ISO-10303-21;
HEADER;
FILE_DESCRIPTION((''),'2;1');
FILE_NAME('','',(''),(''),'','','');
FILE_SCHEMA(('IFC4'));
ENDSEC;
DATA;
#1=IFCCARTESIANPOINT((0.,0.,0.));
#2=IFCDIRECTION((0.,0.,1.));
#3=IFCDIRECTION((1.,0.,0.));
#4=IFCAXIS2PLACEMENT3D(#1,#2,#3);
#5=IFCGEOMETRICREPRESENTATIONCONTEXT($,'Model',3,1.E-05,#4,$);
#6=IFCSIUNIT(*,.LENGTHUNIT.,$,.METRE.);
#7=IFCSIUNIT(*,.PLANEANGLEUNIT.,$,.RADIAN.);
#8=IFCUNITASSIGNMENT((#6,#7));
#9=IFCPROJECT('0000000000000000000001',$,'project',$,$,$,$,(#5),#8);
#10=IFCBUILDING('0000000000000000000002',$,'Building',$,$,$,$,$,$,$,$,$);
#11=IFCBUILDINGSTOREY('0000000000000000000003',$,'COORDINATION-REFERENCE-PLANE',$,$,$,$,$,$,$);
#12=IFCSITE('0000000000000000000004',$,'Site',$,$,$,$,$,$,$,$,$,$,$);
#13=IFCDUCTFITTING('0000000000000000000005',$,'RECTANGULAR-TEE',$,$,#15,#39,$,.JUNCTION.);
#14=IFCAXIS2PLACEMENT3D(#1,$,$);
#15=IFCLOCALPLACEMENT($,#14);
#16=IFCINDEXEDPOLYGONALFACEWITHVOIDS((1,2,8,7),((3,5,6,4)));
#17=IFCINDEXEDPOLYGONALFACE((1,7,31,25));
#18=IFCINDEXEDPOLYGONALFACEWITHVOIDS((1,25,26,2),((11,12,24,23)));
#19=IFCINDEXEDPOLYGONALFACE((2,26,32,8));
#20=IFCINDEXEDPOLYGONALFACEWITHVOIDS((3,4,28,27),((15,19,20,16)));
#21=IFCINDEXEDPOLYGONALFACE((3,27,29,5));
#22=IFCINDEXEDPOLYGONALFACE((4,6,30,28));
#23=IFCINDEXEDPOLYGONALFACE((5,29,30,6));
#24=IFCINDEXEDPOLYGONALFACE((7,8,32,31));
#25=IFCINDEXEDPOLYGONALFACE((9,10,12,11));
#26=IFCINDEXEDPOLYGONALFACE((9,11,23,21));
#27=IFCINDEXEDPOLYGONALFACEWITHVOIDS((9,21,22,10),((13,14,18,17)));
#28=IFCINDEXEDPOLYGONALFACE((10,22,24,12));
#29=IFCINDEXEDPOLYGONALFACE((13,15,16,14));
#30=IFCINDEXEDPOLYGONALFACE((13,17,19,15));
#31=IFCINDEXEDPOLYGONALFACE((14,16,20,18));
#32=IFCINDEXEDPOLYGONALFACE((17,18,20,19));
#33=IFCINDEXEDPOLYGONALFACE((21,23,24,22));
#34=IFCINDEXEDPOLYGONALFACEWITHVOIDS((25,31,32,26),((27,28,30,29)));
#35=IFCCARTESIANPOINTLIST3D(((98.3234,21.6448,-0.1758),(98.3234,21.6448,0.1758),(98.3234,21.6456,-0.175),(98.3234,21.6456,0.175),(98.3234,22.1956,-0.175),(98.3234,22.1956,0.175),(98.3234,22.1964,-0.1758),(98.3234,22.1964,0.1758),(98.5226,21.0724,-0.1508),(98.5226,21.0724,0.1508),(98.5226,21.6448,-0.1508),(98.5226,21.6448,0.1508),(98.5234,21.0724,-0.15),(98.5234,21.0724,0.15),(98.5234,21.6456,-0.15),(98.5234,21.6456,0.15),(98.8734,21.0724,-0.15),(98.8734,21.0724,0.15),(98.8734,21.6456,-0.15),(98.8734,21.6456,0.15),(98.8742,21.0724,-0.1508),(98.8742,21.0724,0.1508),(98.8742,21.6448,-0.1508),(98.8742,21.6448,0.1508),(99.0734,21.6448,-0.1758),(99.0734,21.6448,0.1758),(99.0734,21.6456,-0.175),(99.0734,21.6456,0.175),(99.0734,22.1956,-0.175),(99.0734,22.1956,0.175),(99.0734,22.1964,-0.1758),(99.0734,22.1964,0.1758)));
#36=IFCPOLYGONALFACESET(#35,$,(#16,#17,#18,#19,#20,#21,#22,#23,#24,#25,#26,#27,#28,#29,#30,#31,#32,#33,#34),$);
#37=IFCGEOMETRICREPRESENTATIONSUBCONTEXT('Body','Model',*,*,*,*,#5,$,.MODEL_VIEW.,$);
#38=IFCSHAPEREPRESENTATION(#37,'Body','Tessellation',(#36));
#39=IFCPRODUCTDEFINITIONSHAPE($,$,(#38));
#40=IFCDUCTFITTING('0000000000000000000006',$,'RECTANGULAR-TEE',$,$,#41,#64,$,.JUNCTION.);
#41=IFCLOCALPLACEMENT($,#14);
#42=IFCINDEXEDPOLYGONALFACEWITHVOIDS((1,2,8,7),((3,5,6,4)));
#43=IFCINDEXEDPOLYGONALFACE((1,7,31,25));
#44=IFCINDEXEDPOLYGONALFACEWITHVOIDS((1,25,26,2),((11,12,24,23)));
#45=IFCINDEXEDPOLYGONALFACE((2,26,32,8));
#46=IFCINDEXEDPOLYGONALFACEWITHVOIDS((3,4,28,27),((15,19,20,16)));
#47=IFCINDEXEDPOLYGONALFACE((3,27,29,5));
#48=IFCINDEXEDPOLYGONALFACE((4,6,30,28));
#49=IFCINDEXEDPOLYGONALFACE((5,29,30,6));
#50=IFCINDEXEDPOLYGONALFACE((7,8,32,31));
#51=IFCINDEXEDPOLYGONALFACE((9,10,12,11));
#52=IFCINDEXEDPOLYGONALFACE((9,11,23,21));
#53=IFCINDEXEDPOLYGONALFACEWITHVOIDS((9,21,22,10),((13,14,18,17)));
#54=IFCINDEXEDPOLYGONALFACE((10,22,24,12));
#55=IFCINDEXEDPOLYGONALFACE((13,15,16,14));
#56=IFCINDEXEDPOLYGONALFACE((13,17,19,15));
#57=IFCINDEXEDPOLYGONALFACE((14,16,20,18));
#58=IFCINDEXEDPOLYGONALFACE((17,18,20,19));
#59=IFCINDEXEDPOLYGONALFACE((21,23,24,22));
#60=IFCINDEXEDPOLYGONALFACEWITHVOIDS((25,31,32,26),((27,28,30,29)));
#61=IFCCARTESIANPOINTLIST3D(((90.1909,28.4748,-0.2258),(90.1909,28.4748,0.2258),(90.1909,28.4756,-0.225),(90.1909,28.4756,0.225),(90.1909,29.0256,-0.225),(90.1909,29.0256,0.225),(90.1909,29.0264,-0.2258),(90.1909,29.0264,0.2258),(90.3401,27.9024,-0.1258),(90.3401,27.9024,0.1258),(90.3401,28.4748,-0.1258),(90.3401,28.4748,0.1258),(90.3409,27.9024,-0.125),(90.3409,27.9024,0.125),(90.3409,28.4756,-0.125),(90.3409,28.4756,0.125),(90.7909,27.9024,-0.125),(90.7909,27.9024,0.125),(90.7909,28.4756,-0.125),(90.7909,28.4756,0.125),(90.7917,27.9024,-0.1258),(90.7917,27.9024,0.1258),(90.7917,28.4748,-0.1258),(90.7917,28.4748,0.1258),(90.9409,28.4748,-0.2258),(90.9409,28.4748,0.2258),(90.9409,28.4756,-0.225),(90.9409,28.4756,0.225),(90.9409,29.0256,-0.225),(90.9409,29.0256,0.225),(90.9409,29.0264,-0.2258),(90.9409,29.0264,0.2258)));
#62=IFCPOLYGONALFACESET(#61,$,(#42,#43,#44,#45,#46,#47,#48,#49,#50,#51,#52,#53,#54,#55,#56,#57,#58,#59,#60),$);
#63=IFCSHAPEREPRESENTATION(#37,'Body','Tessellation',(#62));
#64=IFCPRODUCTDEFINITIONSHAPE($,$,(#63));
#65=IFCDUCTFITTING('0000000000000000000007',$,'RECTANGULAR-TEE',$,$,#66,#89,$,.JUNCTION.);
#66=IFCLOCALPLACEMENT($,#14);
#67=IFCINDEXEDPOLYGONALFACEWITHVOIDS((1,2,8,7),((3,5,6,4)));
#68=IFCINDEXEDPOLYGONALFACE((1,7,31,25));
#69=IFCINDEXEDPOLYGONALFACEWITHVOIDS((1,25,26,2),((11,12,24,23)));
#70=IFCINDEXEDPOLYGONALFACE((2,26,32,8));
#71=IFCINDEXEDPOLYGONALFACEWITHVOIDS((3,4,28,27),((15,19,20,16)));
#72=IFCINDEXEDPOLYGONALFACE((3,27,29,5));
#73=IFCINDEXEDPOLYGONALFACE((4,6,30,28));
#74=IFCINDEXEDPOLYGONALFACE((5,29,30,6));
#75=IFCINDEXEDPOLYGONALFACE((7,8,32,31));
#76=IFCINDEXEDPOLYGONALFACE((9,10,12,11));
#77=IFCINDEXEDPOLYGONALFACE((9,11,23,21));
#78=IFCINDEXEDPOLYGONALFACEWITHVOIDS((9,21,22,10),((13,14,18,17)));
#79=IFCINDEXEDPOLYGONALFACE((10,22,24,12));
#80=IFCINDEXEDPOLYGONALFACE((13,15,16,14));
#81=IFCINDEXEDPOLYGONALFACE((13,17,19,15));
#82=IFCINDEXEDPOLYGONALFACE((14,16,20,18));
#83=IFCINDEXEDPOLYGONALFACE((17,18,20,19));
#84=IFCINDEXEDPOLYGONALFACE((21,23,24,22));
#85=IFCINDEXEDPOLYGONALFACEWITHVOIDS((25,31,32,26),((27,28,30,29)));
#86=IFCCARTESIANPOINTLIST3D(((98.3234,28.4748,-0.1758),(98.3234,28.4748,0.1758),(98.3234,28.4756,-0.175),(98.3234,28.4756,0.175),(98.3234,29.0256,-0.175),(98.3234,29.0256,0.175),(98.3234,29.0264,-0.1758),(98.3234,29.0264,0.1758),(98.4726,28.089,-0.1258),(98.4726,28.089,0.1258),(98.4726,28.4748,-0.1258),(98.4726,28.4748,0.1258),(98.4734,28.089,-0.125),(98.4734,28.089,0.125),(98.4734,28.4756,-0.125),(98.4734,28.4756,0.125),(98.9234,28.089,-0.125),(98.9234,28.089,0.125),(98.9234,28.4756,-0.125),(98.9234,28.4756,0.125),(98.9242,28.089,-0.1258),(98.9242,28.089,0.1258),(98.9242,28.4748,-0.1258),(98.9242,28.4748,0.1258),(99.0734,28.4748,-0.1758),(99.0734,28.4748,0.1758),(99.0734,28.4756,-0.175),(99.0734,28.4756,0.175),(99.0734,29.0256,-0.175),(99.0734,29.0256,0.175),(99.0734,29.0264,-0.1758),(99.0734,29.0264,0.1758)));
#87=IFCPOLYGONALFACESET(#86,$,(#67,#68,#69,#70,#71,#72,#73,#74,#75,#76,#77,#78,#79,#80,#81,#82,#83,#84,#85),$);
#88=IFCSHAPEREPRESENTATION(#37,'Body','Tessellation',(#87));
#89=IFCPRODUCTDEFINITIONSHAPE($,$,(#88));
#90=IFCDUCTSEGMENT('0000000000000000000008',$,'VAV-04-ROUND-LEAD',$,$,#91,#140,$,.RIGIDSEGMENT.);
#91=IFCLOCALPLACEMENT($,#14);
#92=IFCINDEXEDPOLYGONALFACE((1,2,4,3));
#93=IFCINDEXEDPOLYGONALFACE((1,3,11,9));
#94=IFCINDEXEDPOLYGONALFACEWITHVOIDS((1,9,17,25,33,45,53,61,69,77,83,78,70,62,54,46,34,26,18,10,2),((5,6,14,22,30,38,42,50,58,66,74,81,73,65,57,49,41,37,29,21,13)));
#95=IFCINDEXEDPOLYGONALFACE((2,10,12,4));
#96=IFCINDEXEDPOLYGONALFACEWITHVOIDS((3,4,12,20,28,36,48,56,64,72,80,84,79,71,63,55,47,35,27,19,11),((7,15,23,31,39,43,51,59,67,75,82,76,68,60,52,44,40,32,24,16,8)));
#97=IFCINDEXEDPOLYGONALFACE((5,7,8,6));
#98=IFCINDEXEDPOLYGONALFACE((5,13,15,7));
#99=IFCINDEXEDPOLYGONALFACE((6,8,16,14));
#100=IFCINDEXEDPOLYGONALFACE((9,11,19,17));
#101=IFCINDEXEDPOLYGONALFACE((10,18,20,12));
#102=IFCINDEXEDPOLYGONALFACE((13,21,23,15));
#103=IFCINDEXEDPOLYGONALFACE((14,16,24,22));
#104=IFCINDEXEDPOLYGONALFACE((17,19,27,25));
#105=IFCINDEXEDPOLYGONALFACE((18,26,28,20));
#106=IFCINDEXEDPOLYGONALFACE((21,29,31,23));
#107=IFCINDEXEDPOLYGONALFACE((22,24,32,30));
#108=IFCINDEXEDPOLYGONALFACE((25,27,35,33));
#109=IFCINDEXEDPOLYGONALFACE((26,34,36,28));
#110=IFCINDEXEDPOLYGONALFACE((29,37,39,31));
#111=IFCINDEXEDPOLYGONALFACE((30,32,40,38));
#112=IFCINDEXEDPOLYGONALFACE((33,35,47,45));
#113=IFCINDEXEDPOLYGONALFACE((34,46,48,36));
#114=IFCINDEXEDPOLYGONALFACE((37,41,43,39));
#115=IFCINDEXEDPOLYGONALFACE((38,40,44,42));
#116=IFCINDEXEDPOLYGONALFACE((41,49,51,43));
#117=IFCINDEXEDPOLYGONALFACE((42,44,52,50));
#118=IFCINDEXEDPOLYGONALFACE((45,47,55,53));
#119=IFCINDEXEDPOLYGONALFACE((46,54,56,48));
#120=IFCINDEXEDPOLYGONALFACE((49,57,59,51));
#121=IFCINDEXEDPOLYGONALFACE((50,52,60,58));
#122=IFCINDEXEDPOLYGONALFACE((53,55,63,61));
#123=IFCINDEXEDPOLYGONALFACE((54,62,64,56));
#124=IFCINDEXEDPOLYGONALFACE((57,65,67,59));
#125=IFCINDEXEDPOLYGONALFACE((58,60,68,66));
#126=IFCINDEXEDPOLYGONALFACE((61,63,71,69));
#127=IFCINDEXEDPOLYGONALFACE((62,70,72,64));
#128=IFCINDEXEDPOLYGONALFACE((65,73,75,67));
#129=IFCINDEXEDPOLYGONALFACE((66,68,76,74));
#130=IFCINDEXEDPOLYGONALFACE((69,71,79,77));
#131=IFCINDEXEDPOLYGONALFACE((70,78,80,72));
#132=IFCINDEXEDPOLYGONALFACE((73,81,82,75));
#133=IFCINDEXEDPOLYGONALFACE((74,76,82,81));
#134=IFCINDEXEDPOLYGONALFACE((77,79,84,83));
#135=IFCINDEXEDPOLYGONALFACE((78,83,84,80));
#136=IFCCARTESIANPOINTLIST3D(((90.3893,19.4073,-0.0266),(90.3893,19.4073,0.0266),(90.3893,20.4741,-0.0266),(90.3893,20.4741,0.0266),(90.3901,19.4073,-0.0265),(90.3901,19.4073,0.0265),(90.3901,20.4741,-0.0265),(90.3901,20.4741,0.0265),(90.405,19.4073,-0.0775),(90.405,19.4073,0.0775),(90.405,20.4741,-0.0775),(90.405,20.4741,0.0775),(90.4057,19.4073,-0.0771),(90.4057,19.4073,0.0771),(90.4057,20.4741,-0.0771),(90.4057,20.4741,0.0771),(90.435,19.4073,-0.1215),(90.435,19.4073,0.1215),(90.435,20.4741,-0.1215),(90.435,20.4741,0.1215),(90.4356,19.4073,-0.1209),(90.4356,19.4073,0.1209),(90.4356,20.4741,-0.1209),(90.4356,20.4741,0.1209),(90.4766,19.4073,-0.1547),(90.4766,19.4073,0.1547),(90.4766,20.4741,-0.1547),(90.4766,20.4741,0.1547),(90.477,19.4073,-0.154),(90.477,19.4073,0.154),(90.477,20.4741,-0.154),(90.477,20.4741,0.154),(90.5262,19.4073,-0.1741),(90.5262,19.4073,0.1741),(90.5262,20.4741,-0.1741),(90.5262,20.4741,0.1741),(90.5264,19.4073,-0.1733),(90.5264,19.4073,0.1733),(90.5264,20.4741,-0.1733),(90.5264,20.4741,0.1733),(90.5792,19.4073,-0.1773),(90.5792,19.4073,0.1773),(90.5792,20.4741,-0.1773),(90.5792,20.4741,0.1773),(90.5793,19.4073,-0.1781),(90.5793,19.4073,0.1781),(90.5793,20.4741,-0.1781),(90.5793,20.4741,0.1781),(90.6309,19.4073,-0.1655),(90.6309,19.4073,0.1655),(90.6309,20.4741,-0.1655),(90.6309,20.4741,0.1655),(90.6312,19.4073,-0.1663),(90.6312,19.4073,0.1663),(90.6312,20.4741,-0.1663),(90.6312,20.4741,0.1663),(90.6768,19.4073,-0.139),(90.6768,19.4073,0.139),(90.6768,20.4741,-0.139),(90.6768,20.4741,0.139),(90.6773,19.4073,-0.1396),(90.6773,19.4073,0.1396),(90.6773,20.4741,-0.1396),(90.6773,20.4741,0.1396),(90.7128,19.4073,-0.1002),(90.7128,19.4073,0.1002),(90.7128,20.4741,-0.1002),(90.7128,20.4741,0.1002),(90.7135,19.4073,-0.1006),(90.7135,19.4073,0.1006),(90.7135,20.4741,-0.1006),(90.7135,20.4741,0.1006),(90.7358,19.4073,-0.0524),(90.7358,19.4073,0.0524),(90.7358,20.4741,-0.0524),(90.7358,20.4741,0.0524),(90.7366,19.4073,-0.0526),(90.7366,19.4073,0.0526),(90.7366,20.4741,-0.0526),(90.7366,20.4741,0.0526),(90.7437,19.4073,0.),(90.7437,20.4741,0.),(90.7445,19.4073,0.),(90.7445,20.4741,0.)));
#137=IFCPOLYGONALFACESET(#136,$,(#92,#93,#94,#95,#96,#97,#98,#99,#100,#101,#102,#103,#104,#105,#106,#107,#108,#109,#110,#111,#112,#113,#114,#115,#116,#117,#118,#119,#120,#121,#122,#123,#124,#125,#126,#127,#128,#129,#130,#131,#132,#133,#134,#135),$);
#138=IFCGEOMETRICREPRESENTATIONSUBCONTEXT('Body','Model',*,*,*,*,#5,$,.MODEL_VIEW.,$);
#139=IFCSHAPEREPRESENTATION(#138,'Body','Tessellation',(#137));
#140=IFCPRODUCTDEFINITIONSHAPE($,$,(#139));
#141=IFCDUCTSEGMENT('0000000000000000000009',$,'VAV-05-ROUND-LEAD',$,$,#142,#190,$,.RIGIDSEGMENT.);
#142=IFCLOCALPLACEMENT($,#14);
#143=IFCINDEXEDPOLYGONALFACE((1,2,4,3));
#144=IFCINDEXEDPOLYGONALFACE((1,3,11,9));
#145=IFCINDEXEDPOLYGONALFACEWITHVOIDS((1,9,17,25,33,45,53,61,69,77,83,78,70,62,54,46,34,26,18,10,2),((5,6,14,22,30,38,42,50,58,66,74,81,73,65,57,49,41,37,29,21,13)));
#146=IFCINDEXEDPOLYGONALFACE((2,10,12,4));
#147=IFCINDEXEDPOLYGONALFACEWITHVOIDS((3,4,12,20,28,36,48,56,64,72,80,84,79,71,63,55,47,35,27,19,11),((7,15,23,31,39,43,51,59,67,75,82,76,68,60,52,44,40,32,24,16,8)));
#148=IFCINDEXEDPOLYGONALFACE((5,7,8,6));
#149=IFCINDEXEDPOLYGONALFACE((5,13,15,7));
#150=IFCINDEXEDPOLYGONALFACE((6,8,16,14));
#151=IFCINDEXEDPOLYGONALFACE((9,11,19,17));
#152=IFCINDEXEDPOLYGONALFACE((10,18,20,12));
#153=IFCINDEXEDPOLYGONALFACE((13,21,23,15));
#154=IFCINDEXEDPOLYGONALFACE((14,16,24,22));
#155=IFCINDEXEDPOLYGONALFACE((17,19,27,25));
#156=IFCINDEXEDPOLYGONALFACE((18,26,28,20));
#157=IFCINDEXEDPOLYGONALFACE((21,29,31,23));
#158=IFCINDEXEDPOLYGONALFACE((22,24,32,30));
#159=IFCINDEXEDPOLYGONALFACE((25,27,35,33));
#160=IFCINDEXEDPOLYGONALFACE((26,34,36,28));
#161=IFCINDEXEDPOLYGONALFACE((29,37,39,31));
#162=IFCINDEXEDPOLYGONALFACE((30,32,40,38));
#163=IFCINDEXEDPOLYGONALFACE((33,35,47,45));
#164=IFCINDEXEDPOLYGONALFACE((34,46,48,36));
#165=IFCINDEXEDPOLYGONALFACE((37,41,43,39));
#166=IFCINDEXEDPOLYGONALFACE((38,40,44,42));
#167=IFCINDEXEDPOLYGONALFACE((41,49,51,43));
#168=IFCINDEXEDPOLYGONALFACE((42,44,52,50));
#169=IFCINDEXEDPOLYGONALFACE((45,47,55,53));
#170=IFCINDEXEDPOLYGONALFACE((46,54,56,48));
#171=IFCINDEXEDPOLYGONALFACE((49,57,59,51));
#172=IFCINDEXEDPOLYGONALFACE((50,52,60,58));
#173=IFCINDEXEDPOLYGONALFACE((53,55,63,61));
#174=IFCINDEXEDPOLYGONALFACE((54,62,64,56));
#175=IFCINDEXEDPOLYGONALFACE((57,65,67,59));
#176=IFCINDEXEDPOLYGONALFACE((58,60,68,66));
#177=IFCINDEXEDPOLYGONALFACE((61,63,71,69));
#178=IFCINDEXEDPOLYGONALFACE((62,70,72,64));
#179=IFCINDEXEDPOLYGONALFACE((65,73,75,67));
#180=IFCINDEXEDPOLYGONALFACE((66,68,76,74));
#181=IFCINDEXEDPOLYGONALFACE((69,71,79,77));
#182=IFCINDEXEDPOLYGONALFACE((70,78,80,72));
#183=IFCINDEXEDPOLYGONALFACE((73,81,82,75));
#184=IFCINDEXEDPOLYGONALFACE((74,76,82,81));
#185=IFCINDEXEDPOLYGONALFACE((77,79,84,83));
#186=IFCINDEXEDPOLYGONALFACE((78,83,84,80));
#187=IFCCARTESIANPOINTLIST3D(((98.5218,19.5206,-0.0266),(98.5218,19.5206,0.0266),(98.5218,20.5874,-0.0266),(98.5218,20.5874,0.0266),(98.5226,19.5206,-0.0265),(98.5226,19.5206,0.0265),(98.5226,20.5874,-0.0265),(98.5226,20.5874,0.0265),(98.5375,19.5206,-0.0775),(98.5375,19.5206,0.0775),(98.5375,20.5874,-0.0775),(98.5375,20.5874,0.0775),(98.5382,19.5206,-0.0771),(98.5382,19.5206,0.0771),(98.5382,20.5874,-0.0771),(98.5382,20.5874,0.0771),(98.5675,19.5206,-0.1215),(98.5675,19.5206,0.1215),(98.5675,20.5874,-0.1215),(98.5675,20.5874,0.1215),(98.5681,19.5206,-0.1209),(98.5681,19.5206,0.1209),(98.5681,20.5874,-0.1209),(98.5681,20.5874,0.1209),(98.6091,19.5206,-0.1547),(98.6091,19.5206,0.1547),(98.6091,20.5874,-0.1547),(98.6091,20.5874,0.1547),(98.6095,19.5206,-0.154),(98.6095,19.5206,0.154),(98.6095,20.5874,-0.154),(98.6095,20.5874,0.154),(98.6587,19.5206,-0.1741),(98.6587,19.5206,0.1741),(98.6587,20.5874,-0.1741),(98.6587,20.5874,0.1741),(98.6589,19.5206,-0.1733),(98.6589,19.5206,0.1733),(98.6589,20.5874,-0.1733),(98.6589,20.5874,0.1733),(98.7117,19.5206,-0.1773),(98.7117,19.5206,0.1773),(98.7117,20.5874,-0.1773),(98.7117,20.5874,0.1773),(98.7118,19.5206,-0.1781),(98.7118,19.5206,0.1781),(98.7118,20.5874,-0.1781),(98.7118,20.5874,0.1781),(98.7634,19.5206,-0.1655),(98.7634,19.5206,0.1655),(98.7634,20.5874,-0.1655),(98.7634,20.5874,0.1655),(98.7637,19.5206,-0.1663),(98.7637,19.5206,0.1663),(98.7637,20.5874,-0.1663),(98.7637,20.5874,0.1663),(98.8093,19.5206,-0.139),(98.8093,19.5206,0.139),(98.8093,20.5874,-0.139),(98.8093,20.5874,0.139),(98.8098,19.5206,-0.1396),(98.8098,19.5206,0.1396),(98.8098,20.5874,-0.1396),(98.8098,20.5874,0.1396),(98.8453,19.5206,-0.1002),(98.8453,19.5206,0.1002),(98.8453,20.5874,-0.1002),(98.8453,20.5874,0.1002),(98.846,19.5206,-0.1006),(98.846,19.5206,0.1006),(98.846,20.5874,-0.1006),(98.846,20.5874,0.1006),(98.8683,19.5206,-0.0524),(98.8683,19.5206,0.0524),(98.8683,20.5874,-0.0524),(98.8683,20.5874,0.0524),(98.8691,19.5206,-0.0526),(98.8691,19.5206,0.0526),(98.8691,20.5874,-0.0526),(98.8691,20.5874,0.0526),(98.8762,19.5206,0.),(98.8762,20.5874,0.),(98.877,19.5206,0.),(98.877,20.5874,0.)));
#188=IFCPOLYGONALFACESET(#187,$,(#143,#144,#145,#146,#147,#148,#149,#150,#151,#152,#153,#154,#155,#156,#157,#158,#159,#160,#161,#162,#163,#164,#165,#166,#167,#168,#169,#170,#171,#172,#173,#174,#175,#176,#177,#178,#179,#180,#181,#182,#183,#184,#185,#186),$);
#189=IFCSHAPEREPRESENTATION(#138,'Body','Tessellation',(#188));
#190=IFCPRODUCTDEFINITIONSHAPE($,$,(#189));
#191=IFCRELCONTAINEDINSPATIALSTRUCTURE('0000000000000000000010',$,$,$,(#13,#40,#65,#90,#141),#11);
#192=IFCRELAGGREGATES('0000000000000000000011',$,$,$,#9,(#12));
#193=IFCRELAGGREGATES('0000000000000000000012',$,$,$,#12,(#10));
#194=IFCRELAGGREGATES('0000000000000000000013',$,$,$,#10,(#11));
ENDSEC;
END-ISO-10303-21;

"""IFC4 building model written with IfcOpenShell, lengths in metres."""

from ifc_helpers import new_model, si_unit, frame, origin, origin_with_axes, place, context, subcontext, project, spatial, rectangle, hollow_circle, extrude, boolean, element, save


model = new_model("IFC4")

# Units and contexts
model_context = context("Model", 3, precision=1e-05, world=origin_with_axes())
body_context_1 = subcontext(model_context, "Body", "Model", "MODEL_VIEW")
body_context_2 = subcontext(model_context, "Body", "Model", "MODEL_VIEW")
ifc_project = project(units=[si_unit("LENGTHUNIT", "METRE"), si_unit("PLANEANGLEUNIT", "RADIAN")], contexts=[model_context])

# Site, building, storey
site = spatial("IfcSite", under=ifc_project, Name="Site")
building = spatial("IfcBuilding", under=site, Name="Building")
storey = spatial("IfcBuildingStorey", under=building, Name="COORDINATION-REFERENCE-PLANE")

# Duct fittings
duct_fitting_1_placement = place(None, frame((98.6984, 21.9206, 0.0), z_axis=(1.0, 0.0, 0.0), x_axis=(0.0, -1.0, 0.0)))
solid_1 = boolean("UNION", extrude(rectangle(XDim=0.55, YDim=0.35), frame((0.0, 0.0, -0.375), z_axis=(0.0, 0.0, 1.0), x_axis=(1.0, 0.0, 0.0)), (0.0, 0.0, 1.0), 0.75), extrude(rectangle(XDim=0.35, YDim=0.3), frame((0.0, 0.0, 0.0), z_axis=(1.0, 0.0, 0.0), x_axis=(0.0, 0.0, -1.0)), (0.0, 0.0, 1.0), 0.8482))
element("IfcDuctFitting", 1, at=duct_fitting_1_placement, inside=storey, Name="RECTANGULAR-TEE", PredefinedType="JUNCTION", context=body_context_1, shape_type="CSG", body=[
    boolean("DIFFERENCE", boolean("UNION", extrude(rectangle(XDim=0.5516, YDim=0.3516), frame((0.0, 0.0, -0.375), z_axis=(0.0, 0.0, 1.0), x_axis=(1.0, 0.0, 0.0)), (0.0, 0.0, 1.0), 0.75), extrude(rectangle(XDim=0.3516, YDim=0.3016), frame((0.0, 0.0, 0.0), z_axis=(1.0, 0.0, 0.0), x_axis=(0.0, 0.0, -1.0)), (0.0, 0.0, 1.0), 0.8482)), solid_1),
])
duct_fitting_2_placement = place(None, frame((90.5659, 28.7506, 0.0), z_axis=(1.0, 0.0, 0.0), x_axis=(0.0, -1.0, 0.0)))
solid_2 = boolean("UNION", extrude(rectangle(XDim=0.55, YDim=0.45), frame((0.0, 0.0, -0.375), z_axis=(0.0, 0.0, 1.0), x_axis=(1.0, 0.0, 0.0)), (0.0, 0.0, 1.0), 0.75), extrude(rectangle(XDim=0.45, YDim=0.25), frame((0.0, 0.0, 0.0), z_axis=(1.0, 0.0, 0.0), x_axis=(0.0, 0.0, -1.0)), (0.0, 0.0, 1.0), 0.8482))
element("IfcDuctFitting", 2, at=duct_fitting_2_placement, inside=storey, Name="RECTANGULAR-TEE", PredefinedType="JUNCTION", context=body_context_1, shape_type="CSG", body=[
    boolean("DIFFERENCE", boolean("UNION", extrude(rectangle(XDim=0.5516, YDim=0.4516), frame((0.0, 0.0, -0.375), z_axis=(0.0, 0.0, 1.0), x_axis=(1.0, 0.0, 0.0)), (0.0, 0.0, 1.0), 0.75), extrude(rectangle(XDim=0.4516, YDim=0.2516), frame((0.0, 0.0, 0.0), z_axis=(1.0, 0.0, 0.0), x_axis=(0.0, 0.0, -1.0)), (0.0, 0.0, 1.0), 0.8482)), solid_2),
])
duct_fitting_3_placement = place(None, frame((98.6984, 28.7506, 0.0), z_axis=(1.0, 0.0, 0.0), x_axis=(0.0, -1.0, 0.0)))
solid_3 = boolean("UNION", extrude(rectangle(XDim=0.55, YDim=0.35), frame((0.0, 0.0, -0.375), z_axis=(0.0, 0.0, 1.0), x_axis=(1.0, 0.0, 0.0)), (0.0, 0.0, 1.0), 0.75), extrude(rectangle(XDim=0.45, YDim=0.25), frame((0.0, 0.0, 0.0), z_axis=(1.0, 0.0, 0.0), x_axis=(0.0, 0.0, -1.0)), (0.0, 0.0, 1.0), 0.6616))
element("IfcDuctFitting", 3, at=duct_fitting_3_placement, inside=storey, Name="RECTANGULAR-TEE", PredefinedType="JUNCTION", context=body_context_1, shape_type="CSG", body=[
    boolean("DIFFERENCE", boolean("UNION", extrude(rectangle(XDim=0.5516, YDim=0.3516), frame((0.0, 0.0, -0.375), z_axis=(0.0, 0.0, 1.0), x_axis=(1.0, 0.0, 0.0)), (0.0, 0.0, 1.0), 0.75), extrude(rectangle(XDim=0.4516, YDim=0.2516), frame((0.0, 0.0, 0.0), z_axis=(1.0, 0.0, 0.0), x_axis=(0.0, 0.0, -1.0)), (0.0, 0.0, 1.0), 0.6616)), solid_3),
])

# Duct segments
for number, where, z_axis, x_axis, name in (
    (4, (90.5659, 20.4741, 0.0), (0.0, -1.0, 0.0), (1.0, 0.0, 0.0), "VAV-04-ROUND-LEAD"),
    (5, (98.6984, 20.5874, 0.0), (0.0, -1.0, 0.0), (1.0, 0.0, 0.0), "VAV-05-ROUND-LEAD"),
):
    element("IfcDuctSegment", number, at=place(None, frame(where, z_axis=z_axis, x_axis=x_axis)), inside=storey, Name=name, PredefinedType="RIGIDSEGMENT", context=body_context_2, shape_type="SweptSolid", body=[
        extrude(hollow_circle(Radius=0.1786, WallThickness=0.0008), origin(), (0.0, 0.0, 1.0), 1.0668),
    ])

save(model, "model.ifc")
